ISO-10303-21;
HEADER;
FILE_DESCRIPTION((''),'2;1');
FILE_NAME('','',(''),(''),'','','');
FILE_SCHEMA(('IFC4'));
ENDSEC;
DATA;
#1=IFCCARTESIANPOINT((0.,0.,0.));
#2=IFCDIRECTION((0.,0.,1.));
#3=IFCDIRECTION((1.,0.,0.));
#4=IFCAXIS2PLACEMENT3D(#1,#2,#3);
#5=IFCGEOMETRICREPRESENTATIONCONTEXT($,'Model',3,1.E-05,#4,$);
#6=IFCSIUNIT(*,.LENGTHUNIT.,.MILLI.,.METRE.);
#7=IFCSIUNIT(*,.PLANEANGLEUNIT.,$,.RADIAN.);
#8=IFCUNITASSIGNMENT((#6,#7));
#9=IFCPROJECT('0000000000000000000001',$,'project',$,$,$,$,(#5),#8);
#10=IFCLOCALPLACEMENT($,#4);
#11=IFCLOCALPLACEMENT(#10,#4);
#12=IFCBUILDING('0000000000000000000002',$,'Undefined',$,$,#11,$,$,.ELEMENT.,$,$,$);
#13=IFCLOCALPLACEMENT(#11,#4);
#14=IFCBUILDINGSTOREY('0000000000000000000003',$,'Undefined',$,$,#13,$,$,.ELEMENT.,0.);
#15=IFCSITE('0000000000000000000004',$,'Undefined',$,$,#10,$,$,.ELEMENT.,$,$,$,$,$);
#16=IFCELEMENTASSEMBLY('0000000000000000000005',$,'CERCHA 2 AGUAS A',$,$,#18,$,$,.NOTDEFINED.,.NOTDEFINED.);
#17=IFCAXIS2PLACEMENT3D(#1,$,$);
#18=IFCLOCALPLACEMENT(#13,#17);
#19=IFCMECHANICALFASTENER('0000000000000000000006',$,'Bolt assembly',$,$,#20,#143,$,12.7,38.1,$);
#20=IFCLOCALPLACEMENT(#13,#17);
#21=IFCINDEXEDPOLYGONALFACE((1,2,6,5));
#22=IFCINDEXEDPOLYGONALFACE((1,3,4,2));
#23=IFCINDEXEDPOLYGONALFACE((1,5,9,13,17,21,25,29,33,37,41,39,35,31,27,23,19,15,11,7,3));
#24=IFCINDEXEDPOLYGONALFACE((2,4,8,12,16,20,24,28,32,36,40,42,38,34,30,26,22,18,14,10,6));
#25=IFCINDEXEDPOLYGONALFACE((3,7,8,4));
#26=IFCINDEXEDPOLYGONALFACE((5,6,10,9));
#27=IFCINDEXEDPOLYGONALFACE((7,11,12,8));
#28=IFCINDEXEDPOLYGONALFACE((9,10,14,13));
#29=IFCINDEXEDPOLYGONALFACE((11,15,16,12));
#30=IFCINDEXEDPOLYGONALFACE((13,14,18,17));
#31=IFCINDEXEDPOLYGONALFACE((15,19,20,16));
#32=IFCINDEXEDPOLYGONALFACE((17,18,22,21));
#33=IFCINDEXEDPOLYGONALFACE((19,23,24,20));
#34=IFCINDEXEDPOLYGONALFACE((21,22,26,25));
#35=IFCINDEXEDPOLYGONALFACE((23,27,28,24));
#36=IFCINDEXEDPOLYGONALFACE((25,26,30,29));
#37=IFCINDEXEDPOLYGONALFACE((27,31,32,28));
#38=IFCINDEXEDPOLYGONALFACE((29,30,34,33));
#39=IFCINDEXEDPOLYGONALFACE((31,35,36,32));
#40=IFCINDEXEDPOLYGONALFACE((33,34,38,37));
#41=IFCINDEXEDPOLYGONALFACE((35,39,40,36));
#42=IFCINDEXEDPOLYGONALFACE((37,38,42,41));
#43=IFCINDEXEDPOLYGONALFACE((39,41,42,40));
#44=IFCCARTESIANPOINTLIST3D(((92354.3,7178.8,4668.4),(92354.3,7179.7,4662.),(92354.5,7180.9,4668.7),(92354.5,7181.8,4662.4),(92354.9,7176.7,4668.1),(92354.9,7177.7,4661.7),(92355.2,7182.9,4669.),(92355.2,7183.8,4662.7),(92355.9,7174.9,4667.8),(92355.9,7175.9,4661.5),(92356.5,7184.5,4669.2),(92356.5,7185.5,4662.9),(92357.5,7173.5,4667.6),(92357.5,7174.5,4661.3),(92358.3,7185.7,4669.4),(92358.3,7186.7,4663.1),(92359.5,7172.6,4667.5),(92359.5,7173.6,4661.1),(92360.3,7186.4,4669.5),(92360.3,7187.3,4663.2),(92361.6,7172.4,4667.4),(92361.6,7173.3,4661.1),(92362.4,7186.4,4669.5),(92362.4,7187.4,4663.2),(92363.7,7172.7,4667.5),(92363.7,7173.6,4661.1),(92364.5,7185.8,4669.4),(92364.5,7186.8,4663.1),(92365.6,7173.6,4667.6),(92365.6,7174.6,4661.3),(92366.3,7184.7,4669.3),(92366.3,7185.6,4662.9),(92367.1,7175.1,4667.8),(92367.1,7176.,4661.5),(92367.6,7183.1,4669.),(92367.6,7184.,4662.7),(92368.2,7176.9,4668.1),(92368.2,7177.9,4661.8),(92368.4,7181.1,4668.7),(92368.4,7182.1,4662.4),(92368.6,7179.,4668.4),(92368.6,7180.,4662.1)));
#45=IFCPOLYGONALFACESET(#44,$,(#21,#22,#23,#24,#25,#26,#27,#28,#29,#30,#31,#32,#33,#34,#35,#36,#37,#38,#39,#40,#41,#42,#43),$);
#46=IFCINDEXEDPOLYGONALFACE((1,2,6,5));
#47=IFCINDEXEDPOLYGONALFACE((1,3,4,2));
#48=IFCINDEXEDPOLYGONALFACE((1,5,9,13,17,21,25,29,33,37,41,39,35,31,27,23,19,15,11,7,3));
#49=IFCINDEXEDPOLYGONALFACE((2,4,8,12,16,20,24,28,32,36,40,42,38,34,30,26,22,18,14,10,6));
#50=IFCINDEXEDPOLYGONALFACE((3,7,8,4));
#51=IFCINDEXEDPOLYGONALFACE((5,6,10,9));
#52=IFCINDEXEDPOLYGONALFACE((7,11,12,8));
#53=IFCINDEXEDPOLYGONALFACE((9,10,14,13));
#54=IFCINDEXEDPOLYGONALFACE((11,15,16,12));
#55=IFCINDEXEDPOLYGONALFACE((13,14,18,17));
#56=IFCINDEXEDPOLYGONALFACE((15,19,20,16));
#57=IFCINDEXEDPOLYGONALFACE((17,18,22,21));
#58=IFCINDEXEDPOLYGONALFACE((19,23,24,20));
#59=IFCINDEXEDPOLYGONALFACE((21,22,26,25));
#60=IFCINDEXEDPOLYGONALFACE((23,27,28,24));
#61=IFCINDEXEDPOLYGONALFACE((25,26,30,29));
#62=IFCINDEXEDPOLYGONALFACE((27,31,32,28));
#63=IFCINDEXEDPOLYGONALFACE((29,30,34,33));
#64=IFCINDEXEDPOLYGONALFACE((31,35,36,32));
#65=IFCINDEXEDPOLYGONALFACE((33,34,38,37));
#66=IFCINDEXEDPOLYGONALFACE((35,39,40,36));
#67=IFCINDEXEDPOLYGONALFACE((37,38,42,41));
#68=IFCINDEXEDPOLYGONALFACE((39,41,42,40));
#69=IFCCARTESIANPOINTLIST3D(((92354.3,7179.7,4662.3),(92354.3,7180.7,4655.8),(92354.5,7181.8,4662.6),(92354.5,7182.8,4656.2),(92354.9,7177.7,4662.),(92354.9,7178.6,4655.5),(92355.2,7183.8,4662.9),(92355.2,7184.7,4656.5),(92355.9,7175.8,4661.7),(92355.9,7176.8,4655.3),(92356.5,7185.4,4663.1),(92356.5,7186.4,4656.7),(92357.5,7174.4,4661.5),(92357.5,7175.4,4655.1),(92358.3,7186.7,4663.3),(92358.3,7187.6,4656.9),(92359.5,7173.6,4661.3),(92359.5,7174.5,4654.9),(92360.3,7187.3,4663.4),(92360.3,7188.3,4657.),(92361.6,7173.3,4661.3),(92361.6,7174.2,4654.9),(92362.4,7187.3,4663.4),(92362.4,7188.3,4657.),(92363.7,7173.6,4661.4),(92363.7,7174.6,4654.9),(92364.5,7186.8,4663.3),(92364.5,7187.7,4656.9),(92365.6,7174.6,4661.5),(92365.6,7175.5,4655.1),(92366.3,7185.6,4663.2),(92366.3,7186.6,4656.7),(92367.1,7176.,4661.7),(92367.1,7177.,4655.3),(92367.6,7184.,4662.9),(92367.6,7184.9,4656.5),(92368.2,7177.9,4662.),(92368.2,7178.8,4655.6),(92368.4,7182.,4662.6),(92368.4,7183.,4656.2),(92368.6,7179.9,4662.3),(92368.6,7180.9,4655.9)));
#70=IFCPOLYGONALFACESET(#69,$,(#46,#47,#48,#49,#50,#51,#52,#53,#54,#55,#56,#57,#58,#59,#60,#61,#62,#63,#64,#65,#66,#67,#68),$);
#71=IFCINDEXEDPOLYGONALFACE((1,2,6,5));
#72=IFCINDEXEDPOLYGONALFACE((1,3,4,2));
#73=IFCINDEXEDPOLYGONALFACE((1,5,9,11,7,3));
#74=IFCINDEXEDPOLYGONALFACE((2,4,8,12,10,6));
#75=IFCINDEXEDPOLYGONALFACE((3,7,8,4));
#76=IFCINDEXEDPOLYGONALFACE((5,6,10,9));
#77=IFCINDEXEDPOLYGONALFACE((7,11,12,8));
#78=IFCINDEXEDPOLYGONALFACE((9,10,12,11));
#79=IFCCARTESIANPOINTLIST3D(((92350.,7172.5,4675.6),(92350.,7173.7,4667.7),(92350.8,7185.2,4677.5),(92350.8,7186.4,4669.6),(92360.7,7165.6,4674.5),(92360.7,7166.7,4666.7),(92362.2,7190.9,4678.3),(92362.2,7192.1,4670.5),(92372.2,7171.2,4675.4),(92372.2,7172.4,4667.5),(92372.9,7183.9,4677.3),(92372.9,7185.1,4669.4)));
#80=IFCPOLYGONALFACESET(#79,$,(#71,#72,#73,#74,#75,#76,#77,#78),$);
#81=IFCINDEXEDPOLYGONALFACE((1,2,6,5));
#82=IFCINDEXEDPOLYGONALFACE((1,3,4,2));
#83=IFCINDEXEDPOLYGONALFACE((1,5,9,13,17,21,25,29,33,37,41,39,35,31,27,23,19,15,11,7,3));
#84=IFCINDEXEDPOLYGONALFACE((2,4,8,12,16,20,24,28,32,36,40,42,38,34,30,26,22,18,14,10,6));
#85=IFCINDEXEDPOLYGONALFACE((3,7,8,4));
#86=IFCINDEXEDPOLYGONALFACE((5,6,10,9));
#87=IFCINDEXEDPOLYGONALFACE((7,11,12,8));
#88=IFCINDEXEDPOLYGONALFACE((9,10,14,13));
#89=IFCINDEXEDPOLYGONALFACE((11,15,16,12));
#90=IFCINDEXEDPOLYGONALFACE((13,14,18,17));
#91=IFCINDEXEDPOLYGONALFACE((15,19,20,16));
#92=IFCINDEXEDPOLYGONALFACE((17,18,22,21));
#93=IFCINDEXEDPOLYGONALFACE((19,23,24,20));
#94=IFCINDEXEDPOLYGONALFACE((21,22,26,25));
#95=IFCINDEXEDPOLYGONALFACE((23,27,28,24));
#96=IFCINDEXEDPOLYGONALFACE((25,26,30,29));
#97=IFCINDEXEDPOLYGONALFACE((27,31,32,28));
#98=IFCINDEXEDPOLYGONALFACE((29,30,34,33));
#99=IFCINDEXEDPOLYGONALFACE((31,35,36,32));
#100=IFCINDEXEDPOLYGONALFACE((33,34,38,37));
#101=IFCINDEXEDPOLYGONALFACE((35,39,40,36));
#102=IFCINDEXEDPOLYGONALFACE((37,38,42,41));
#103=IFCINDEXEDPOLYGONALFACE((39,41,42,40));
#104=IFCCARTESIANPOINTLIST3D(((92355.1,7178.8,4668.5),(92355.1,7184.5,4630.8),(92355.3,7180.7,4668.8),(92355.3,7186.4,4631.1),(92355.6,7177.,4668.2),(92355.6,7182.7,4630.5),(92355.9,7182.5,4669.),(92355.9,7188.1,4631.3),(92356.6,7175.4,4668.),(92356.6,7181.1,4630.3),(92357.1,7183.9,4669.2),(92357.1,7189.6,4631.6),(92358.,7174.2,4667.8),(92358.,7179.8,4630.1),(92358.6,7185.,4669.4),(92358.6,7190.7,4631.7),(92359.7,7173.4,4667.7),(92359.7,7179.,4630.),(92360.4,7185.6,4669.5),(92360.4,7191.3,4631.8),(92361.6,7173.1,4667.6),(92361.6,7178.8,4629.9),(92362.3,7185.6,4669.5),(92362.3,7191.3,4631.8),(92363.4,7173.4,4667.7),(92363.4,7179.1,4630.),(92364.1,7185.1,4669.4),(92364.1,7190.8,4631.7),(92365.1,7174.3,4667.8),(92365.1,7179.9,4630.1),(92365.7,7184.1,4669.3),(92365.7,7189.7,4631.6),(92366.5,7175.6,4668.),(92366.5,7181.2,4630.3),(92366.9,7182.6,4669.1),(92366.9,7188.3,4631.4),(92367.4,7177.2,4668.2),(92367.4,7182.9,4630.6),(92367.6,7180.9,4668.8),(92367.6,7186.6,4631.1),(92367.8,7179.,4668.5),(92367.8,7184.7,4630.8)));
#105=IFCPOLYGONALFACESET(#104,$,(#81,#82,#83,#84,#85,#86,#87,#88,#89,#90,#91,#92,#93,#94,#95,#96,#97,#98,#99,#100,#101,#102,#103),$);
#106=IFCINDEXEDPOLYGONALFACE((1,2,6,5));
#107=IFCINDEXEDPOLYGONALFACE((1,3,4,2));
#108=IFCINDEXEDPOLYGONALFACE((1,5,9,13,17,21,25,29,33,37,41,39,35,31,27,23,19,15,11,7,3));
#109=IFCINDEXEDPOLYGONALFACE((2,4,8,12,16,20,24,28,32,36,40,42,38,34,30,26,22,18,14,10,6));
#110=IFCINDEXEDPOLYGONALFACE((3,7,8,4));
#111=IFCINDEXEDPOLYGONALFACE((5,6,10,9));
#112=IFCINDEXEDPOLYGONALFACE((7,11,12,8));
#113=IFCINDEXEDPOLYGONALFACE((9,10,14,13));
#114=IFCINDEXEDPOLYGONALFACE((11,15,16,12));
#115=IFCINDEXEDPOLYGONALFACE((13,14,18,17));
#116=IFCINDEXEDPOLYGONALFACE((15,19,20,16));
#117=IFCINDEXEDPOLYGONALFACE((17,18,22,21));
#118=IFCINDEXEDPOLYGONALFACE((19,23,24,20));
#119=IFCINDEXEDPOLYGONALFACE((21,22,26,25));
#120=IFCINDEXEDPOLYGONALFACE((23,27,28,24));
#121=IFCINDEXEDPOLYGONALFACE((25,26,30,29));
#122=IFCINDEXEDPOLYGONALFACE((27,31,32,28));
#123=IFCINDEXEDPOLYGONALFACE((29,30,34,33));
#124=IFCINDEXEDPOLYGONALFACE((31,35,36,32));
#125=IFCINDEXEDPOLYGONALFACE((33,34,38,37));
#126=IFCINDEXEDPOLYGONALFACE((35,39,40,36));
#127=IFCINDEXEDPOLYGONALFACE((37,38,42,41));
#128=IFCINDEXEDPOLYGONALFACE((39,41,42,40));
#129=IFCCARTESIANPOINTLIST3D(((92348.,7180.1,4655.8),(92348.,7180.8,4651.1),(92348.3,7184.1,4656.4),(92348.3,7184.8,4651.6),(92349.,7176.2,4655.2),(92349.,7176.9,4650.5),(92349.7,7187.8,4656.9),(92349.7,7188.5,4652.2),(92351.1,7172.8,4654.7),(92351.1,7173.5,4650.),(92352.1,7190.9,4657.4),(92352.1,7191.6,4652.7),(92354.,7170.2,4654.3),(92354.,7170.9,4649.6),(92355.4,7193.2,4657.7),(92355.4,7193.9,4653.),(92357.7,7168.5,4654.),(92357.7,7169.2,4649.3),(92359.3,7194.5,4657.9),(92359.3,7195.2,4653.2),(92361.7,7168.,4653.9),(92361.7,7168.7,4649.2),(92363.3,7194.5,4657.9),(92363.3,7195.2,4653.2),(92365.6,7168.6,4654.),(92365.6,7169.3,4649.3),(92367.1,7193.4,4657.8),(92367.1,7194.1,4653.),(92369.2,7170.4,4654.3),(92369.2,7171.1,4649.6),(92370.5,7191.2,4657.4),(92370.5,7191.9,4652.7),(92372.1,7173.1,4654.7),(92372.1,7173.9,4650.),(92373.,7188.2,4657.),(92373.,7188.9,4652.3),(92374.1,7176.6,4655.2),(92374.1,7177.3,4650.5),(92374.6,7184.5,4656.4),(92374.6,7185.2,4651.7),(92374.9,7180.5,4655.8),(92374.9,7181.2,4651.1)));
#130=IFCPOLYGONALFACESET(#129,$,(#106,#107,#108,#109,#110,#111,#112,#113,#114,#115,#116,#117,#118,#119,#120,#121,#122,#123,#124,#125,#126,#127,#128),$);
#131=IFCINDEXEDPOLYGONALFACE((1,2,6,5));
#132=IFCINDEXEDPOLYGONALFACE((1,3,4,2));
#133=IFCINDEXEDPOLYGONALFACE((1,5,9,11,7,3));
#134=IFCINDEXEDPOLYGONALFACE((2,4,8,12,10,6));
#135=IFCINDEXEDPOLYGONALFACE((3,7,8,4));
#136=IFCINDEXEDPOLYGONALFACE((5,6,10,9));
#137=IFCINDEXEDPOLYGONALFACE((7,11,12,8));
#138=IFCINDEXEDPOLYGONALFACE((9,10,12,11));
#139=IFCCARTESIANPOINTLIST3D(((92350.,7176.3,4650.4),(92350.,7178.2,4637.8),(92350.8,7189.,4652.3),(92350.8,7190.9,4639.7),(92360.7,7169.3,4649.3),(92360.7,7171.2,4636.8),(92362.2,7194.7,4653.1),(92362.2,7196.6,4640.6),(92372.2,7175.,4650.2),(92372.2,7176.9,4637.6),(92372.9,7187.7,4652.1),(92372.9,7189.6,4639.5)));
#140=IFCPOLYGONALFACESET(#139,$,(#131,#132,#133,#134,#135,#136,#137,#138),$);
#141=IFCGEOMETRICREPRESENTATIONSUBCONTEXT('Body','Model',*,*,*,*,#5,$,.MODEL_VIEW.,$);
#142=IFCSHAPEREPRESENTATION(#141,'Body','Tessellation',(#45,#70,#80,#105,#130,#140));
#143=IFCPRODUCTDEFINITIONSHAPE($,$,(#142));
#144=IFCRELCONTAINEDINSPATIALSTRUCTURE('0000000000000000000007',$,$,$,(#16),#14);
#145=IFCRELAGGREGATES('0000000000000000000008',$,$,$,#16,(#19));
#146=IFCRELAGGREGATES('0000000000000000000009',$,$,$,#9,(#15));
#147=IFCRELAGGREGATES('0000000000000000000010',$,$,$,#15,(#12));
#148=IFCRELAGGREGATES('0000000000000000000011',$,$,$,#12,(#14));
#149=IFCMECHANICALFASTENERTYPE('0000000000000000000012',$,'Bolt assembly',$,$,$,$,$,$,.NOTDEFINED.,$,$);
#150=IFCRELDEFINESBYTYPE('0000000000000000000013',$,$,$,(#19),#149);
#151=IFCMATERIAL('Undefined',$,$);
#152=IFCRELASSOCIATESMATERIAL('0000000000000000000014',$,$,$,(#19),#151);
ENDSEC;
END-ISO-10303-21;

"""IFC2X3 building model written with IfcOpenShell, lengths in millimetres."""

from ifc_helpers import new_model, si_unit, frame, origin_with_axes, origin_2d_with_axis, place, context, subcontext, project, spatial, polyline, circle, outline, extrude, source, transform, mapped, material, type_object, element, aggregate, save


model = new_model("IFC2X3")

# Units and contexts
model_context = context("Model", 3, precision=1e-05, world=origin_with_axes())
body_context = subcontext(model_context, "Body", "Model", "MODEL_VIEW")
ifc_project = project(units=[si_unit("LENGTHUNIT", "METRE", prefix="MILLI"), si_unit("PLANEANGLEUNIT", "RADIAN")], contexts=[model_context])

# Site, building, storey
site_placement = place(None, origin_with_axes())
site = spatial("IfcSite", under=ifc_project, at=site_placement, Name="Undefined", CompositionType="ELEMENT")
building_placement = place(site_placement, origin_with_axes())
building = spatial("IfcBuilding", under=site, at=building_placement, Name="Undefined", CompositionType="ELEMENT")
storey_placement = place(building_placement, origin_with_axes())
storey = spatial("IfcBuildingStorey", under=building, at=storey_placement, Name="Undefined", CompositionType="ELEMENT", Elevation=0.0)

# Element assembly
assembly_1_placement = place(storey_placement, origin_with_axes())
assembly_1 = element("IfcElementAssembly", 1, at=assembly_1_placement, inside=storey, Name="CERCHA 2 AGUAS A", AssemblyPlace="NOTDEFINED", PredefinedType="NOTDEFINED")

# Shared definitions
ifc_material_1 = material(Name="Undefined")
mechanical_fastener_type = type_object("IfcMechanicalFastenerType", Name="Bolt assembly")

# Mechanical fastener
shared_shape_1 = source(origin_with_axes(), body_context, "Body", "SweptSolid", [
    extrude(circle(Radius=7.1, at=origin_2d_with_axis()), frame((0.0, -6.3, 0.0), z_axis=(0.0, 1.0, 0.0), x_axis=(1.0, 0.0, 0.0)), (0.0, 0.0, 1.0), 6.4),
    extrude(circle(Radius=7.1, at=origin_2d_with_axis()), frame((0.0, -0.1, 0.0), z_axis=(0.0, 1.0, 0.0), x_axis=(1.0, 0.0, 0.0)), (0.0, 0.0, 1.0), 6.5),
    extrude(outline(polyline([(11.1, -6.4), (11.1, 6.4), (0.0, 12.8), (-11.1, 6.4), (-11.1, -6.4), (0.0, -12.8), (11.1, -6.4)])), frame((0.0, -14.3, 0.0), z_axis=(0.0, 1.0, 0.0), x_axis=(1.0, 0.0, 0.0)), (0.0, 0.0, 1.0), 7.9),
    extrude(circle(Radius=6.3, at=origin_2d_with_axis()), frame((0.0, -6.4, 0.0), z_axis=(0.0, 1.0, 0.0), x_axis=(1.0, 0.0, 0.0)), (0.0, 0.0, 1.0), 38.1),
    extrude(circle(Radius=13.5, at=origin_2d_with_axis()), frame((0.0, 6.4, 0.0), z_axis=(0.0, 1.0, 0.0), x_axis=(1.0, 0.0, 0.0)), (0.0, 0.0, 1.0), 4.8),
    extrude(outline(polyline([(11.1, -6.4), (11.1, 6.4), (0.0, 12.8), (-11.1, 6.4), (-11.1, -6.4), (0.0, -12.8), (11.1, -6.4)])), frame((0.0, 11.2, 0.0), z_axis=(0.0, 1.0, 0.0), x_axis=(1.0, 0.0, 0.0)), (0.0, 0.0, 1.0), 12.7),
])
mechanical_fastener_1_placement = place(assembly_1_placement, frame((92361.5, 7180.4, 4662.3), z_axis=(0.834881, -0.544341, -0.081651), x_axis=(-0.55043, -0.825644, -0.123847)))
mechanical_fastener_1 = element("IfcMechanicalFastener", 2, at=mechanical_fastener_1_placement, type_object=mechanical_fastener_type, material=ifc_material_1, Name="Bolt assembly", NominalDiameter=12.7, NominalLength=38.1, context=body_context, shape_type="MappedRepresentation", body=[
    mapped(shared_shape_1, transform((0.0, 0.0, 0.0))),
])
aggregate(assembly_1, [mechanical_fastener_1])

save(model, "model.ifc")
